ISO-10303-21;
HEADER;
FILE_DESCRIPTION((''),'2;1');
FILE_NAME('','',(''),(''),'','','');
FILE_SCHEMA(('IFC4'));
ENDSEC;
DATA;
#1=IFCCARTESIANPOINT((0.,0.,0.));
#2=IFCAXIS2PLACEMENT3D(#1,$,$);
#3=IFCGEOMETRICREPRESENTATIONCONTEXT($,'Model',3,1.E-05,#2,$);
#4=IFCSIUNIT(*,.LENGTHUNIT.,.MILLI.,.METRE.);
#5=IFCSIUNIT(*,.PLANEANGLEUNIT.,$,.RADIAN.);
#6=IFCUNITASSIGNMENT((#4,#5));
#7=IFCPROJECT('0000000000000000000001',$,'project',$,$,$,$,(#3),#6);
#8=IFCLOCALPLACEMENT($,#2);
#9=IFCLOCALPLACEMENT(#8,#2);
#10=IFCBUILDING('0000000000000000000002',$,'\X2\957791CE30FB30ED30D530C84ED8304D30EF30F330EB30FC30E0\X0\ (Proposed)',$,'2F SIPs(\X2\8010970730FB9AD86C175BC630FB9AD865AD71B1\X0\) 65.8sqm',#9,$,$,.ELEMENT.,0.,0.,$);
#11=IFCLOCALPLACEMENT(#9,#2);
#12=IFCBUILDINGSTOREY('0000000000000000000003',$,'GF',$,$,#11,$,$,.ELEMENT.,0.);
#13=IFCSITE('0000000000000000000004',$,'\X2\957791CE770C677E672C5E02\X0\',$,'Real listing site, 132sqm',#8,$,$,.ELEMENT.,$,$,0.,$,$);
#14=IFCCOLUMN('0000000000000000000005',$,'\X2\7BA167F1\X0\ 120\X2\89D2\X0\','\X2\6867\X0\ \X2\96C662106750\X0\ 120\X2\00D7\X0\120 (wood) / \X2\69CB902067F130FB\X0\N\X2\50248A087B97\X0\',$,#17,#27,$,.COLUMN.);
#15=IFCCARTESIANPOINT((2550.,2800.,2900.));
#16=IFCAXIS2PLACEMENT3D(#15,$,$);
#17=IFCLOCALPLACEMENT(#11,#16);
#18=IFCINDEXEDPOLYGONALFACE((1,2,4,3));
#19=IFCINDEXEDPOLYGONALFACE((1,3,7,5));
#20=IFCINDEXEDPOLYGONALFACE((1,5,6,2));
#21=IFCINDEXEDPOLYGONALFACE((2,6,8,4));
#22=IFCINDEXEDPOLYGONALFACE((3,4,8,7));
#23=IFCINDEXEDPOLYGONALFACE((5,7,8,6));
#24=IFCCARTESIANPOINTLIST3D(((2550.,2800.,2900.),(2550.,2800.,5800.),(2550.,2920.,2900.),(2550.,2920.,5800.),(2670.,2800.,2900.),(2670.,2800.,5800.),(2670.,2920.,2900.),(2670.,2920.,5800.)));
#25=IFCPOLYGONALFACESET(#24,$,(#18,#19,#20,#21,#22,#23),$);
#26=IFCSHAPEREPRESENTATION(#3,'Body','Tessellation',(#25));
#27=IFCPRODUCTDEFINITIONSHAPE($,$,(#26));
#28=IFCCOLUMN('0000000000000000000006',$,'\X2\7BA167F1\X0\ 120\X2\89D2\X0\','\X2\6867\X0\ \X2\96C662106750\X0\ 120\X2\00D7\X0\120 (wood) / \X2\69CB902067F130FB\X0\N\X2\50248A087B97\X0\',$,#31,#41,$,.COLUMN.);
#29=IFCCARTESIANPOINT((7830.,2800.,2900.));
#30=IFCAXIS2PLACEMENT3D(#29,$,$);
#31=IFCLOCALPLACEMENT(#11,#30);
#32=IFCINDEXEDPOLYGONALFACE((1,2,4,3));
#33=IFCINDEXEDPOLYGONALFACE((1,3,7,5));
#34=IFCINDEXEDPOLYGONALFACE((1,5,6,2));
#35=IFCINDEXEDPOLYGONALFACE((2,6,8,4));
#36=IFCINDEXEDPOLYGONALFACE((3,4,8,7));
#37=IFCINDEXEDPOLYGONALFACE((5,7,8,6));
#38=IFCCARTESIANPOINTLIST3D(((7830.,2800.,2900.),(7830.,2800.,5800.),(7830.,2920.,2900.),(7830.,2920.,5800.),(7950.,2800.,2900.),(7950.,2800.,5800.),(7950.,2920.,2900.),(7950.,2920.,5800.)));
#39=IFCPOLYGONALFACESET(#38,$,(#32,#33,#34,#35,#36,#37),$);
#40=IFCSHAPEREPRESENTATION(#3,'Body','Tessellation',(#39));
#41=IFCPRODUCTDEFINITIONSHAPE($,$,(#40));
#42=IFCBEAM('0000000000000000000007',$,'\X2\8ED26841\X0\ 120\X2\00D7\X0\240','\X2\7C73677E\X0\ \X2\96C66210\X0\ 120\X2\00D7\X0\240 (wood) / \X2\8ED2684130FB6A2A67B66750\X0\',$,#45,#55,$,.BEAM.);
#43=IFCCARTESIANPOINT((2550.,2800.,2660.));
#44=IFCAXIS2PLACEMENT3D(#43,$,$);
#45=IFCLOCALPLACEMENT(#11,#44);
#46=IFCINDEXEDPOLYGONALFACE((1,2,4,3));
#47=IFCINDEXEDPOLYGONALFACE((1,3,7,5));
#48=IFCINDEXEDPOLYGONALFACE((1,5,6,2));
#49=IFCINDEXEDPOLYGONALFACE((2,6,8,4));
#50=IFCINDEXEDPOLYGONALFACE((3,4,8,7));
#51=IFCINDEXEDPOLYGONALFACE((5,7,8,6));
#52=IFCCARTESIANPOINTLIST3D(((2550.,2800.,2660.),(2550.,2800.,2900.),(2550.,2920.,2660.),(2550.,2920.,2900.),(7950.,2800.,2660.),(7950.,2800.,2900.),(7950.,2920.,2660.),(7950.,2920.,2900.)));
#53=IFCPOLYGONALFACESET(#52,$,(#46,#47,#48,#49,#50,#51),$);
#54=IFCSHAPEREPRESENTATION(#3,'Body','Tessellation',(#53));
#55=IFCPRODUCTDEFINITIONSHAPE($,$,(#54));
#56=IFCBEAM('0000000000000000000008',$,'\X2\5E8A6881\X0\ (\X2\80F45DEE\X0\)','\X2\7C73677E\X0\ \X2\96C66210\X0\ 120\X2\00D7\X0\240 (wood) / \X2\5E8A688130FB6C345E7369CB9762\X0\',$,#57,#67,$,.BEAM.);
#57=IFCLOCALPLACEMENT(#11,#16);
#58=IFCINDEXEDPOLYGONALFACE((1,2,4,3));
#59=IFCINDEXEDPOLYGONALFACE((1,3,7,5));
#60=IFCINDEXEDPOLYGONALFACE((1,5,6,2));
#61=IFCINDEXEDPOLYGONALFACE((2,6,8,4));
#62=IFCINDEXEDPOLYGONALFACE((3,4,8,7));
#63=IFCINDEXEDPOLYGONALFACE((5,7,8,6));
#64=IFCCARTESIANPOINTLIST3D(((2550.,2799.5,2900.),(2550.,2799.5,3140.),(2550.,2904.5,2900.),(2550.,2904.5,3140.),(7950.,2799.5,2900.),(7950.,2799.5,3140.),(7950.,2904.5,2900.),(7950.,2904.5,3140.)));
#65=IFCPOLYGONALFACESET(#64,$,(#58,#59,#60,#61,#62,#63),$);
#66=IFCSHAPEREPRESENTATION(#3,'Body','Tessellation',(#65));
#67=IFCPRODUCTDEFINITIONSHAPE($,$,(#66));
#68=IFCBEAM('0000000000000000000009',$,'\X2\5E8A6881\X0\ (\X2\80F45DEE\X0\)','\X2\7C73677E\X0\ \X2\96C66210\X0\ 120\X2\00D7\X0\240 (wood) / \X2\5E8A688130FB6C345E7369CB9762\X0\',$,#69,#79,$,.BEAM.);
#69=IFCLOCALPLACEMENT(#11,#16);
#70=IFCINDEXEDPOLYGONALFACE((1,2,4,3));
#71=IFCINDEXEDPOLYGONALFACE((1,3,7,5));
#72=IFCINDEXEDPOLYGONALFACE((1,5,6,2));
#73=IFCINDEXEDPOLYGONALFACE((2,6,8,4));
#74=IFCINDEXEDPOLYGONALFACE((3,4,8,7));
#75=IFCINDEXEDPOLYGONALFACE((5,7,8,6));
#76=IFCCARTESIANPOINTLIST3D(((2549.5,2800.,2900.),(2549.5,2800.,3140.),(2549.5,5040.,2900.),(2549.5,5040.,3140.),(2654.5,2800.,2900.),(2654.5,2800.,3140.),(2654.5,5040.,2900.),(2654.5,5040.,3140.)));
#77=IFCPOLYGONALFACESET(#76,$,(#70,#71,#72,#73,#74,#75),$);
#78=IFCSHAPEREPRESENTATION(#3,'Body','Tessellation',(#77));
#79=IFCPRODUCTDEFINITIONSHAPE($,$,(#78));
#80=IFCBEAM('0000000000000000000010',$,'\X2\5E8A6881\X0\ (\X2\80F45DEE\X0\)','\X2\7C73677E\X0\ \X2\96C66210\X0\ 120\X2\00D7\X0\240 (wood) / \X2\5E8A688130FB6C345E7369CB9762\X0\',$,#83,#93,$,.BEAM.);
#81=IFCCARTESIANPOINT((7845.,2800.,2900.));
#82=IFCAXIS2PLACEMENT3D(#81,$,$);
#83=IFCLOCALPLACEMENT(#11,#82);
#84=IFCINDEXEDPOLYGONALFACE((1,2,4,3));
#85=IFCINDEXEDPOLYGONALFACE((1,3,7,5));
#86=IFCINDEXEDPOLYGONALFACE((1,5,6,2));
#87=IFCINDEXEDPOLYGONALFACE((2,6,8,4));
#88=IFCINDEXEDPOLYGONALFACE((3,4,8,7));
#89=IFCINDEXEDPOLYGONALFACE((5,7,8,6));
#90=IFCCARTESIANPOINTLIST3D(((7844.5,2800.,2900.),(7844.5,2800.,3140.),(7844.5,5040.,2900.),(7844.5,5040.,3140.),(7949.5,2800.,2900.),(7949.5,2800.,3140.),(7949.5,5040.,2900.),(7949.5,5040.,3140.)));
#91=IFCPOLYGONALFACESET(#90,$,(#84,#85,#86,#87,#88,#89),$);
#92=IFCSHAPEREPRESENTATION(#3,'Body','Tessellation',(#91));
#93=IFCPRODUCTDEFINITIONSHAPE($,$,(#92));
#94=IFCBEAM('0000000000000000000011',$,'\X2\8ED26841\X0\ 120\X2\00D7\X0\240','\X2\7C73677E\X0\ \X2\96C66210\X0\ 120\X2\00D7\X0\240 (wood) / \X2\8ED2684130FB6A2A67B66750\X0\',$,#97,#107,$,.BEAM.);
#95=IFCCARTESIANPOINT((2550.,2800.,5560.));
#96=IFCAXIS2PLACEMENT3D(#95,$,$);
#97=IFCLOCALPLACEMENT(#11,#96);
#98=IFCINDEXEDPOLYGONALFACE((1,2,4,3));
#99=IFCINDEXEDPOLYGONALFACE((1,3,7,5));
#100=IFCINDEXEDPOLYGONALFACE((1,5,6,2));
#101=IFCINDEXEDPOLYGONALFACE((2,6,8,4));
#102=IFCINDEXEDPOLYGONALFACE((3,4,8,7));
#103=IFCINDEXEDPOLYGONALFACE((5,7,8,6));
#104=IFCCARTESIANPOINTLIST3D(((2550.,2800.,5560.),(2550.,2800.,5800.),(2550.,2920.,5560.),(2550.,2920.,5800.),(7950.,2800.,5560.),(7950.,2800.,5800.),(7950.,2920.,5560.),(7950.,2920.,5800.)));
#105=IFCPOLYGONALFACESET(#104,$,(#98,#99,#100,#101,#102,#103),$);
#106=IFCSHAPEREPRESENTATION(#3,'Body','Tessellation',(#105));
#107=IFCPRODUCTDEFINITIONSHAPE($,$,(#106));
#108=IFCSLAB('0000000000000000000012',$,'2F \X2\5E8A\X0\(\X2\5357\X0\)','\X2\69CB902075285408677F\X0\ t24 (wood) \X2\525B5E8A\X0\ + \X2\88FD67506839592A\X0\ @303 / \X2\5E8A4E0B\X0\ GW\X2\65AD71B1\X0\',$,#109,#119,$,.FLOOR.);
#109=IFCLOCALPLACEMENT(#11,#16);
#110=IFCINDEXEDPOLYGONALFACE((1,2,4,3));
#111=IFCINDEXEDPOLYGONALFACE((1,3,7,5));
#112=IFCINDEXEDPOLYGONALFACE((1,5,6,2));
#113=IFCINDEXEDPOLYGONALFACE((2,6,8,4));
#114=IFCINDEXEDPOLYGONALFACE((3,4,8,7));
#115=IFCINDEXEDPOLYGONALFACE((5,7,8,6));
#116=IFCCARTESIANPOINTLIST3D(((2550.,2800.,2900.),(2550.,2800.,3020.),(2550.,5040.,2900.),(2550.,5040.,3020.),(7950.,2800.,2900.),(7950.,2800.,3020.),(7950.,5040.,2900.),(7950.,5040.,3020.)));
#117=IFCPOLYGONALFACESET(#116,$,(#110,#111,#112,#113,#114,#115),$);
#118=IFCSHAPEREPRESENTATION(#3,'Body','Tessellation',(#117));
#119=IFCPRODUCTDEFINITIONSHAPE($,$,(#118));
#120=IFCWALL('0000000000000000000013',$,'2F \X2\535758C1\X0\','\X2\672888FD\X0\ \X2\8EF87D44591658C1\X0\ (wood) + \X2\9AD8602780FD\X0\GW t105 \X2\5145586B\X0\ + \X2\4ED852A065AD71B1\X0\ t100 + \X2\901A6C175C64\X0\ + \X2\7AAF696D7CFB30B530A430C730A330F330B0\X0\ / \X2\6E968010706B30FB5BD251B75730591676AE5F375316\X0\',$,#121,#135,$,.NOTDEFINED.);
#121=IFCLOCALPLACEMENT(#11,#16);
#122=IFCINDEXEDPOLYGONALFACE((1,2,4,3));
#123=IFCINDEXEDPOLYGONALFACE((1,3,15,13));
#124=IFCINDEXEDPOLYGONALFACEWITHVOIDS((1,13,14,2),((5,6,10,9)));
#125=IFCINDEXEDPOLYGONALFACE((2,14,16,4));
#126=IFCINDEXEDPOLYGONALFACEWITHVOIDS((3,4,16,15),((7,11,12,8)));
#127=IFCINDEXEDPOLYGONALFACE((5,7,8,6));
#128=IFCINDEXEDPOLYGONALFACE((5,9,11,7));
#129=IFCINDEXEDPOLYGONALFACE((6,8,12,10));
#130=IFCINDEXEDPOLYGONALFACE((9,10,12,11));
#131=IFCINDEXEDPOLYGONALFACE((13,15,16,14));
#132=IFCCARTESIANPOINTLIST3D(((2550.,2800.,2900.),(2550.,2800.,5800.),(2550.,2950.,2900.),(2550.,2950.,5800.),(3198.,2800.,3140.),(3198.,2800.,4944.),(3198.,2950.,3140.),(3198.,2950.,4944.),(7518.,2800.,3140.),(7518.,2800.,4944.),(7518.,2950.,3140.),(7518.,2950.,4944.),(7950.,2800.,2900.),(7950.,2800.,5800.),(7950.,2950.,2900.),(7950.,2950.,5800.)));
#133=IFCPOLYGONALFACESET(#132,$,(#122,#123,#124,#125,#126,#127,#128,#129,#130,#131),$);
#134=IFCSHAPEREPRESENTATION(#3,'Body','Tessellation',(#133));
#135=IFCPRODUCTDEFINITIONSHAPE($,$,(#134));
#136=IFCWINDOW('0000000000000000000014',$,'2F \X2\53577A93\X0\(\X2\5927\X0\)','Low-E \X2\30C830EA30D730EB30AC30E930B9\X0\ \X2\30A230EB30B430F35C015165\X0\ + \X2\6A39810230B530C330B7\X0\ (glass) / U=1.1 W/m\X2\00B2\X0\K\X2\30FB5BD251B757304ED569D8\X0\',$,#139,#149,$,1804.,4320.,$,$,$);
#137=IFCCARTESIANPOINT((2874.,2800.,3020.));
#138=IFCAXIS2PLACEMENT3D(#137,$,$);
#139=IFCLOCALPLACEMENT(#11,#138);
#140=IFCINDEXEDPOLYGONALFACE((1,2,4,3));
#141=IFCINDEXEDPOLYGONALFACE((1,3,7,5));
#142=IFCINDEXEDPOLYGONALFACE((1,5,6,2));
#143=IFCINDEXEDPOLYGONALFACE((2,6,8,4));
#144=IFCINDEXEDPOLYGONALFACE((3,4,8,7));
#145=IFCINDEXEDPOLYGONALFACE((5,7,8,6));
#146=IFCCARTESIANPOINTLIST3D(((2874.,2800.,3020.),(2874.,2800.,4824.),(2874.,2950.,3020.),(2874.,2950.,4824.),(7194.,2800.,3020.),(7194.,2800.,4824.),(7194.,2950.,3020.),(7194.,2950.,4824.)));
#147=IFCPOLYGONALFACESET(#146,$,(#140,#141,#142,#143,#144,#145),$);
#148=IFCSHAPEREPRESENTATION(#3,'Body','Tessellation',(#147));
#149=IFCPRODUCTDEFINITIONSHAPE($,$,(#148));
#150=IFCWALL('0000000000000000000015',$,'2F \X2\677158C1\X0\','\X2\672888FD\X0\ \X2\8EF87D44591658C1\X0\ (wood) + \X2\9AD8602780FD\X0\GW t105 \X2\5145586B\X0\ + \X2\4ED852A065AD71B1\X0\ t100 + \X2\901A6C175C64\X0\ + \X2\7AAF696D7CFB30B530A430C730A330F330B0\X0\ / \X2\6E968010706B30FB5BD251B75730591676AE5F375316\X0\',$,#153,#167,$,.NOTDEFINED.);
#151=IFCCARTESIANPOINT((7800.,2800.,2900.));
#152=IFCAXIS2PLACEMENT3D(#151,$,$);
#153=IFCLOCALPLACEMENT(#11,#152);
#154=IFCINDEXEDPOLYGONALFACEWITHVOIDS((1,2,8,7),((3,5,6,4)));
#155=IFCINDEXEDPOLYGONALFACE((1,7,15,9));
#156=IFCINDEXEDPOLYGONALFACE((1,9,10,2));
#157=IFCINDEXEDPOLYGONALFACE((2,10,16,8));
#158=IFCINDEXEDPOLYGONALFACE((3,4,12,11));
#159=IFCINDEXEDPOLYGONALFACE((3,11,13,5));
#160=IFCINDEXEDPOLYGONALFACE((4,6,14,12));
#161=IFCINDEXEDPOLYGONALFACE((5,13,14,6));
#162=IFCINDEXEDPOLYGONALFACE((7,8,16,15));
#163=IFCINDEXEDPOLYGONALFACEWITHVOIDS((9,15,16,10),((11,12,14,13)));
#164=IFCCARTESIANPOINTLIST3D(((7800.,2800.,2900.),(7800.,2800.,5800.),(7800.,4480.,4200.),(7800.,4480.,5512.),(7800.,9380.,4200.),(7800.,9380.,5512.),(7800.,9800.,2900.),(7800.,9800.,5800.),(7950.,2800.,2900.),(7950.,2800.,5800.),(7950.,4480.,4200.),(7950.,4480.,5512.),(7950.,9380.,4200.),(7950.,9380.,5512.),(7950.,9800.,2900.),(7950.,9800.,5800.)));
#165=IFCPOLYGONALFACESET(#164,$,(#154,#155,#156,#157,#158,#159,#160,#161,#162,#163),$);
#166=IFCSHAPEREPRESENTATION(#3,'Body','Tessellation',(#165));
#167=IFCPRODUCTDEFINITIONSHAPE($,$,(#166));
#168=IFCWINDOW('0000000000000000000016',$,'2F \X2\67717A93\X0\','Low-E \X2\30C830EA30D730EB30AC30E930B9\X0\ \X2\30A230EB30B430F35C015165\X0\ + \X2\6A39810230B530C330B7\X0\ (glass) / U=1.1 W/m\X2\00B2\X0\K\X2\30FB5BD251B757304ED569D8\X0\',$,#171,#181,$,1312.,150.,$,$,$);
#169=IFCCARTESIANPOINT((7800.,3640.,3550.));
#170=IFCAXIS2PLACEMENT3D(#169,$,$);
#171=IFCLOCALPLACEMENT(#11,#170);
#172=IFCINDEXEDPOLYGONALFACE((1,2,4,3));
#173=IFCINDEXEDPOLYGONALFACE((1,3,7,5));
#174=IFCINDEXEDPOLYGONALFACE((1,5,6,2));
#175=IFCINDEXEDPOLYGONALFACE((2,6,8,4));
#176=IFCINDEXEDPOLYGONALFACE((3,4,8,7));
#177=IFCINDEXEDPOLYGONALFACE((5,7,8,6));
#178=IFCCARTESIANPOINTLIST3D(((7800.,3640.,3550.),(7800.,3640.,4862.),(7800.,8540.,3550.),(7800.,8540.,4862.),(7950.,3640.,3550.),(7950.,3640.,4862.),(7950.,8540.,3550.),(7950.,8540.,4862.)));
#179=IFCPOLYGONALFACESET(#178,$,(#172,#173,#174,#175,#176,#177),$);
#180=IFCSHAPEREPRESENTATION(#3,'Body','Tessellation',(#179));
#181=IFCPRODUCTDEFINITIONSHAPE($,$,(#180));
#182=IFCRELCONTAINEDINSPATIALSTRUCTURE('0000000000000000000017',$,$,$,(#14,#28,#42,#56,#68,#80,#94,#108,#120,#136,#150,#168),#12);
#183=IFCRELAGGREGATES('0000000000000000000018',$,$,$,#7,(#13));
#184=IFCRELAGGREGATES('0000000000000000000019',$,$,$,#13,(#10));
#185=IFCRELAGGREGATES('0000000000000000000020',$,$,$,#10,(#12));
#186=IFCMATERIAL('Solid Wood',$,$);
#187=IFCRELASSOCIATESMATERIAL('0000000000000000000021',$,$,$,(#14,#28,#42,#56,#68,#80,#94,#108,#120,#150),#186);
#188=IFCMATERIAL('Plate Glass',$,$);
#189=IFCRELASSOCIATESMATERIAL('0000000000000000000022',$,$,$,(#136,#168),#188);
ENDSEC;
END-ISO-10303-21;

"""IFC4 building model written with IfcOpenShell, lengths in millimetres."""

from ifc_helpers import new_model, si_unit, frame, frame_2d, origin, place, context, project, spatial, rectangle, extrude, material, element, fill, save


model = new_model("IFC4")

# Units and contexts
model_context = context("Model", 3, precision=1e-05, world=origin())
ifc_project = project(units=[si_unit("LENGTHUNIT", "METRE", prefix="MILLI"), si_unit("PLANEANGLEUNIT", "RADIAN")], contexts=[model_context])

# Site, building, storey
site_placement = place(None, origin())
site = spatial("IfcSite", under=ifc_project, at=site_placement, Name="長野県松本市", ObjectType="Real listing site, 132sqm", CompositionType="ELEMENT", RefElevation=0.0)
building_placement = place(site_placement, origin())
building = spatial("IfcBuilding", under=site, at=building_placement, Name="長野・ロフト付きワンルーム (Proposed)", ObjectType="2F SIPs(耐震・高気密・高断熱) 65.8sqm", CompositionType="ELEMENT", ElevationOfRefHeight=0.0, ElevationOfTerrain=0.0)
storey_placement = place(building_placement, origin())
storey = spatial("IfcBuildingStorey", under=building, at=storey_placement, Name="GF", CompositionType="ELEMENT", Elevation=0.0)

# Columns
ifc_material_1 = material(Name="Solid Wood")
column_1_placement = place(storey_placement, frame((2550.0, 2800.0, 2900.0)))
element("IfcColumn", 1, at=column_1_placement, inside=storey, material=ifc_material_1, Name="管柱 120角", Description="桧 集成材 120×120 (wood) / 構造柱・N値計算", PredefinedType="COLUMN", context=model_context, shape_type="SweptSolid", body=[
    extrude(rectangle(XDim=120.0, YDim=120.0, at=frame_2d((60.0, 60.0))), frame((2550.0, 2800.0, 2900.0)), (0.0, 0.0, 1.0), 2900.0),
])
column_2_placement = place(storey_placement, frame((7830.0, 2800.0, 2900.0)))
element("IfcColumn", 2, at=column_2_placement, inside=storey, material=ifc_material_1, Name="管柱 120角", Description="桧 集成材 120×120 (wood) / 構造柱・N値計算", PredefinedType="COLUMN", context=model_context, shape_type="SweptSolid", body=[
    extrude(rectangle(XDim=120.0, YDim=120.0, at=frame_2d((60.0, 60.0))), frame((7830.0, 2800.0, 2900.0)), (0.0, 0.0, 1.0), 2900.0),
])

# Beams
beam_1_placement = place(storey_placement, frame((2550.0, 2800.0, 2660.0)))
element("IfcBeam", 3, at=beam_1_placement, inside=storey, material=ifc_material_1, Name="軒桁 120×240", Description="米松 集成 120×240 (wood) / 軒桁・横架材", PredefinedType="BEAM", context=model_context, shape_type="SweptSolid", body=[
    extrude(rectangle(XDim=5400.0, YDim=120.0, at=frame_2d((2700.0, 60.0))), frame((2550.0, 2800.0, 2660.0)), (0.0, 0.0, 1.0), 240.0),
])
beam_2_placement = place(storey_placement, frame((2550.0, 2800.0, 2900.0)))
element("IfcBeam", 4, at=beam_2_placement, inside=storey, material=ifc_material_1, Name="床梁 (胴差)", Description="米松 集成 120×240 (wood) / 床梁・水平構面", PredefinedType="BEAM", context=model_context, shape_type="SweptSolid", body=[
    extrude(rectangle(XDim=5400.0, YDim=105.0, at=frame_2d((2700.0, 52.0))), frame((2550.0, 2800.0, 2900.0)), (0.0, 0.0, 1.0), 240.0),
])
beam_3_placement = place(storey_placement, frame((2550.0, 2800.0, 2900.0)))
element("IfcBeam", 5, at=beam_3_placement, inside=storey, material=ifc_material_1, Name="床梁 (胴差)", Description="米松 集成 120×240 (wood) / 床梁・水平構面", PredefinedType="BEAM", context=model_context, shape_type="SweptSolid", body=[
    extrude(rectangle(XDim=105.0, YDim=2240.0, at=frame_2d((52.0, 1120.0))), frame((2550.0, 2800.0, 2900.0)), (0.0, 0.0, 1.0), 240.0),
])
beam_4_placement = place(storey_placement, frame((7845.0, 2800.0, 2900.0)))
element("IfcBeam", 6, at=beam_4_placement, inside=storey, material=ifc_material_1, Name="床梁 (胴差)", Description="米松 集成 120×240 (wood) / 床梁・水平構面", PredefinedType="BEAM", context=model_context, shape_type="SweptSolid", body=[
    extrude(rectangle(XDim=105.0, YDim=2240.0, at=frame_2d((52.0, 1120.0))), frame((7845.0, 2800.0, 2900.0)), (0.0, 0.0, 1.0), 240.0),
])
beam_5_placement = place(storey_placement, frame((2550.0, 2800.0, 5560.0)))
element("IfcBeam", 7, at=beam_5_placement, inside=storey, material=ifc_material_1, Name="軒桁 120×240", Description="米松 集成 120×240 (wood) / 軒桁・横架材", PredefinedType="BEAM", context=model_context, shape_type="SweptSolid", body=[
    extrude(rectangle(XDim=5400.0, YDim=120.0, at=frame_2d((2700.0, 60.0))), frame((2550.0, 2800.0, 5560.0)), (0.0, 0.0, 1.0), 240.0),
])

# Slab
slab_placement = place(storey_placement, frame((2550.0, 2800.0, 2900.0)))
element("IfcSlab", 8, at=slab_placement, inside=storey, material=ifc_material_1, Name="2F 床(南)", Description="構造用合板 t24 (wood) 剛床 + 製材根太 @303 / 床下 GW断熱", PredefinedType="FLOOR", context=model_context, shape_type="SweptSolid", body=[
    extrude(rectangle(XDim=5400.0, YDim=2240.0, at=frame_2d((2700.0, 1120.0))), frame((2550.0, 2800.0, 2900.0)), (0.0, 0.0, 1.0), 120.0),
])

# Walls, openings, windows
wall_1_placement = place(storey_placement, frame((2550.0, 2800.0, 2900.0)))
wall_1 = element("IfcWall", 9, at=wall_1_placement, inside=storey, material=ifc_material_1, Name="2F 南壁", Description="木製 軸組外壁 (wood) + 高性能GW t105 充填 + 付加断熱 t100 + 通気層 + 窯業系サイディング / 準耐火・寒冷地外皮強化", PredefinedType="NOTDEFINED", context=model_context, shape_type="SweptSolid", body=[
    extrude(rectangle(XDim=5400.0, YDim=150.0, at=frame_2d((2700.0, 75.0))), frame((2550.0, 2800.0, 2900.0)), (0.0, 0.0, 1.0), 2900.0),
])
opening_1_placement = place(storey_placement, frame((2874.0, 2800.0, 3020.0)))
opening_1 = element("IfcOpeningElement", 10, at=opening_1_placement, cuts=wall_1, PredefinedType="NOTDEFINED", context=model_context, shape_type="SweptSolid", body=[
    extrude(rectangle(XDim=4320.0, YDim=150.0, at=frame_2d((2160.0, 75.0))), frame((2874.0, 2800.0, 3020.0)), (0.0, 0.0, 1.0), 1804.0),
])
ifc_material_2 = material(Name="Plate Glass")
window_1_placement = place(storey_placement, frame((2874.0, 2800.0, 3020.0)))
window_1 = element("IfcWindow", 11, at=window_1_placement, inside=storey, material=ifc_material_2, Name="2F 南窓(大)", Description="Low-E トリプルガラス アルゴン封入 + 樹脂サッシ (glass) / U=1.1 W/m²K・寒冷地仕様", OverallHeight=1804.0, OverallWidth=4320.0, context=model_context, shape_type="SweptSolid", body=[
    extrude(rectangle(XDim=4320.0, YDim=150.0, at=frame_2d((2160.0, 75.0))), frame((2874.0, 2800.0, 3020.0)), (0.0, 0.0, 1.0), 1804.0),
])
fill(opening_1, window_1)
wall_2_placement = place(storey_placement, frame((7800.0, 2800.0, 2900.0)))
wall_2 = element("IfcWall", 12, at=wall_2_placement, inside=storey, material=ifc_material_1, Name="2F 東壁", Description="木製 軸組外壁 (wood) + 高性能GW t105 充填 + 付加断熱 t100 + 通気層 + 窯業系サイディング / 準耐火・寒冷地外皮強化", PredefinedType="NOTDEFINED", context=model_context, shape_type="SweptSolid", body=[
    extrude(rectangle(XDim=150.0, YDim=7000.0, at=frame_2d((75.0, 3500.0))), frame((7800.0, 2800.0, 2900.0)), (0.0, 0.0, 1.0), 2900.0),
])
opening_2_placement = place(storey_placement, frame((7800.0, 3640.0, 3550.0)))
opening_2 = element("IfcOpeningElement", 13, at=opening_2_placement, cuts=wall_2, PredefinedType="NOTDEFINED", context=model_context, shape_type="SweptSolid", body=[
    extrude(rectangle(XDim=150.0, YDim=4900.0, at=frame_2d((75.0, 2450.0))), frame((7800.0, 3640.0, 3550.0)), (0.0, 0.0, 1.0), 1312.0),
])
window_2_placement = place(storey_placement, frame((7800.0, 3640.0, 3550.0)))
window_2 = element("IfcWindow", 14, at=window_2_placement, inside=storey, material=ifc_material_2, Name="2F 東窓", Description="Low-E トリプルガラス アルゴン封入 + 樹脂サッシ (glass) / U=1.1 W/m²K・寒冷地仕様", OverallHeight=1312.0, OverallWidth=150.0, context=model_context, shape_type="SweptSolid", body=[
    extrude(rectangle(XDim=150.0, YDim=4900.0, at=frame_2d((75.0, 2450.0))), frame((7800.0, 3640.0, 3550.0)), (0.0, 0.0, 1.0), 1312.0),
])
fill(opening_2, window_2)

save(model, "model.ifc")
